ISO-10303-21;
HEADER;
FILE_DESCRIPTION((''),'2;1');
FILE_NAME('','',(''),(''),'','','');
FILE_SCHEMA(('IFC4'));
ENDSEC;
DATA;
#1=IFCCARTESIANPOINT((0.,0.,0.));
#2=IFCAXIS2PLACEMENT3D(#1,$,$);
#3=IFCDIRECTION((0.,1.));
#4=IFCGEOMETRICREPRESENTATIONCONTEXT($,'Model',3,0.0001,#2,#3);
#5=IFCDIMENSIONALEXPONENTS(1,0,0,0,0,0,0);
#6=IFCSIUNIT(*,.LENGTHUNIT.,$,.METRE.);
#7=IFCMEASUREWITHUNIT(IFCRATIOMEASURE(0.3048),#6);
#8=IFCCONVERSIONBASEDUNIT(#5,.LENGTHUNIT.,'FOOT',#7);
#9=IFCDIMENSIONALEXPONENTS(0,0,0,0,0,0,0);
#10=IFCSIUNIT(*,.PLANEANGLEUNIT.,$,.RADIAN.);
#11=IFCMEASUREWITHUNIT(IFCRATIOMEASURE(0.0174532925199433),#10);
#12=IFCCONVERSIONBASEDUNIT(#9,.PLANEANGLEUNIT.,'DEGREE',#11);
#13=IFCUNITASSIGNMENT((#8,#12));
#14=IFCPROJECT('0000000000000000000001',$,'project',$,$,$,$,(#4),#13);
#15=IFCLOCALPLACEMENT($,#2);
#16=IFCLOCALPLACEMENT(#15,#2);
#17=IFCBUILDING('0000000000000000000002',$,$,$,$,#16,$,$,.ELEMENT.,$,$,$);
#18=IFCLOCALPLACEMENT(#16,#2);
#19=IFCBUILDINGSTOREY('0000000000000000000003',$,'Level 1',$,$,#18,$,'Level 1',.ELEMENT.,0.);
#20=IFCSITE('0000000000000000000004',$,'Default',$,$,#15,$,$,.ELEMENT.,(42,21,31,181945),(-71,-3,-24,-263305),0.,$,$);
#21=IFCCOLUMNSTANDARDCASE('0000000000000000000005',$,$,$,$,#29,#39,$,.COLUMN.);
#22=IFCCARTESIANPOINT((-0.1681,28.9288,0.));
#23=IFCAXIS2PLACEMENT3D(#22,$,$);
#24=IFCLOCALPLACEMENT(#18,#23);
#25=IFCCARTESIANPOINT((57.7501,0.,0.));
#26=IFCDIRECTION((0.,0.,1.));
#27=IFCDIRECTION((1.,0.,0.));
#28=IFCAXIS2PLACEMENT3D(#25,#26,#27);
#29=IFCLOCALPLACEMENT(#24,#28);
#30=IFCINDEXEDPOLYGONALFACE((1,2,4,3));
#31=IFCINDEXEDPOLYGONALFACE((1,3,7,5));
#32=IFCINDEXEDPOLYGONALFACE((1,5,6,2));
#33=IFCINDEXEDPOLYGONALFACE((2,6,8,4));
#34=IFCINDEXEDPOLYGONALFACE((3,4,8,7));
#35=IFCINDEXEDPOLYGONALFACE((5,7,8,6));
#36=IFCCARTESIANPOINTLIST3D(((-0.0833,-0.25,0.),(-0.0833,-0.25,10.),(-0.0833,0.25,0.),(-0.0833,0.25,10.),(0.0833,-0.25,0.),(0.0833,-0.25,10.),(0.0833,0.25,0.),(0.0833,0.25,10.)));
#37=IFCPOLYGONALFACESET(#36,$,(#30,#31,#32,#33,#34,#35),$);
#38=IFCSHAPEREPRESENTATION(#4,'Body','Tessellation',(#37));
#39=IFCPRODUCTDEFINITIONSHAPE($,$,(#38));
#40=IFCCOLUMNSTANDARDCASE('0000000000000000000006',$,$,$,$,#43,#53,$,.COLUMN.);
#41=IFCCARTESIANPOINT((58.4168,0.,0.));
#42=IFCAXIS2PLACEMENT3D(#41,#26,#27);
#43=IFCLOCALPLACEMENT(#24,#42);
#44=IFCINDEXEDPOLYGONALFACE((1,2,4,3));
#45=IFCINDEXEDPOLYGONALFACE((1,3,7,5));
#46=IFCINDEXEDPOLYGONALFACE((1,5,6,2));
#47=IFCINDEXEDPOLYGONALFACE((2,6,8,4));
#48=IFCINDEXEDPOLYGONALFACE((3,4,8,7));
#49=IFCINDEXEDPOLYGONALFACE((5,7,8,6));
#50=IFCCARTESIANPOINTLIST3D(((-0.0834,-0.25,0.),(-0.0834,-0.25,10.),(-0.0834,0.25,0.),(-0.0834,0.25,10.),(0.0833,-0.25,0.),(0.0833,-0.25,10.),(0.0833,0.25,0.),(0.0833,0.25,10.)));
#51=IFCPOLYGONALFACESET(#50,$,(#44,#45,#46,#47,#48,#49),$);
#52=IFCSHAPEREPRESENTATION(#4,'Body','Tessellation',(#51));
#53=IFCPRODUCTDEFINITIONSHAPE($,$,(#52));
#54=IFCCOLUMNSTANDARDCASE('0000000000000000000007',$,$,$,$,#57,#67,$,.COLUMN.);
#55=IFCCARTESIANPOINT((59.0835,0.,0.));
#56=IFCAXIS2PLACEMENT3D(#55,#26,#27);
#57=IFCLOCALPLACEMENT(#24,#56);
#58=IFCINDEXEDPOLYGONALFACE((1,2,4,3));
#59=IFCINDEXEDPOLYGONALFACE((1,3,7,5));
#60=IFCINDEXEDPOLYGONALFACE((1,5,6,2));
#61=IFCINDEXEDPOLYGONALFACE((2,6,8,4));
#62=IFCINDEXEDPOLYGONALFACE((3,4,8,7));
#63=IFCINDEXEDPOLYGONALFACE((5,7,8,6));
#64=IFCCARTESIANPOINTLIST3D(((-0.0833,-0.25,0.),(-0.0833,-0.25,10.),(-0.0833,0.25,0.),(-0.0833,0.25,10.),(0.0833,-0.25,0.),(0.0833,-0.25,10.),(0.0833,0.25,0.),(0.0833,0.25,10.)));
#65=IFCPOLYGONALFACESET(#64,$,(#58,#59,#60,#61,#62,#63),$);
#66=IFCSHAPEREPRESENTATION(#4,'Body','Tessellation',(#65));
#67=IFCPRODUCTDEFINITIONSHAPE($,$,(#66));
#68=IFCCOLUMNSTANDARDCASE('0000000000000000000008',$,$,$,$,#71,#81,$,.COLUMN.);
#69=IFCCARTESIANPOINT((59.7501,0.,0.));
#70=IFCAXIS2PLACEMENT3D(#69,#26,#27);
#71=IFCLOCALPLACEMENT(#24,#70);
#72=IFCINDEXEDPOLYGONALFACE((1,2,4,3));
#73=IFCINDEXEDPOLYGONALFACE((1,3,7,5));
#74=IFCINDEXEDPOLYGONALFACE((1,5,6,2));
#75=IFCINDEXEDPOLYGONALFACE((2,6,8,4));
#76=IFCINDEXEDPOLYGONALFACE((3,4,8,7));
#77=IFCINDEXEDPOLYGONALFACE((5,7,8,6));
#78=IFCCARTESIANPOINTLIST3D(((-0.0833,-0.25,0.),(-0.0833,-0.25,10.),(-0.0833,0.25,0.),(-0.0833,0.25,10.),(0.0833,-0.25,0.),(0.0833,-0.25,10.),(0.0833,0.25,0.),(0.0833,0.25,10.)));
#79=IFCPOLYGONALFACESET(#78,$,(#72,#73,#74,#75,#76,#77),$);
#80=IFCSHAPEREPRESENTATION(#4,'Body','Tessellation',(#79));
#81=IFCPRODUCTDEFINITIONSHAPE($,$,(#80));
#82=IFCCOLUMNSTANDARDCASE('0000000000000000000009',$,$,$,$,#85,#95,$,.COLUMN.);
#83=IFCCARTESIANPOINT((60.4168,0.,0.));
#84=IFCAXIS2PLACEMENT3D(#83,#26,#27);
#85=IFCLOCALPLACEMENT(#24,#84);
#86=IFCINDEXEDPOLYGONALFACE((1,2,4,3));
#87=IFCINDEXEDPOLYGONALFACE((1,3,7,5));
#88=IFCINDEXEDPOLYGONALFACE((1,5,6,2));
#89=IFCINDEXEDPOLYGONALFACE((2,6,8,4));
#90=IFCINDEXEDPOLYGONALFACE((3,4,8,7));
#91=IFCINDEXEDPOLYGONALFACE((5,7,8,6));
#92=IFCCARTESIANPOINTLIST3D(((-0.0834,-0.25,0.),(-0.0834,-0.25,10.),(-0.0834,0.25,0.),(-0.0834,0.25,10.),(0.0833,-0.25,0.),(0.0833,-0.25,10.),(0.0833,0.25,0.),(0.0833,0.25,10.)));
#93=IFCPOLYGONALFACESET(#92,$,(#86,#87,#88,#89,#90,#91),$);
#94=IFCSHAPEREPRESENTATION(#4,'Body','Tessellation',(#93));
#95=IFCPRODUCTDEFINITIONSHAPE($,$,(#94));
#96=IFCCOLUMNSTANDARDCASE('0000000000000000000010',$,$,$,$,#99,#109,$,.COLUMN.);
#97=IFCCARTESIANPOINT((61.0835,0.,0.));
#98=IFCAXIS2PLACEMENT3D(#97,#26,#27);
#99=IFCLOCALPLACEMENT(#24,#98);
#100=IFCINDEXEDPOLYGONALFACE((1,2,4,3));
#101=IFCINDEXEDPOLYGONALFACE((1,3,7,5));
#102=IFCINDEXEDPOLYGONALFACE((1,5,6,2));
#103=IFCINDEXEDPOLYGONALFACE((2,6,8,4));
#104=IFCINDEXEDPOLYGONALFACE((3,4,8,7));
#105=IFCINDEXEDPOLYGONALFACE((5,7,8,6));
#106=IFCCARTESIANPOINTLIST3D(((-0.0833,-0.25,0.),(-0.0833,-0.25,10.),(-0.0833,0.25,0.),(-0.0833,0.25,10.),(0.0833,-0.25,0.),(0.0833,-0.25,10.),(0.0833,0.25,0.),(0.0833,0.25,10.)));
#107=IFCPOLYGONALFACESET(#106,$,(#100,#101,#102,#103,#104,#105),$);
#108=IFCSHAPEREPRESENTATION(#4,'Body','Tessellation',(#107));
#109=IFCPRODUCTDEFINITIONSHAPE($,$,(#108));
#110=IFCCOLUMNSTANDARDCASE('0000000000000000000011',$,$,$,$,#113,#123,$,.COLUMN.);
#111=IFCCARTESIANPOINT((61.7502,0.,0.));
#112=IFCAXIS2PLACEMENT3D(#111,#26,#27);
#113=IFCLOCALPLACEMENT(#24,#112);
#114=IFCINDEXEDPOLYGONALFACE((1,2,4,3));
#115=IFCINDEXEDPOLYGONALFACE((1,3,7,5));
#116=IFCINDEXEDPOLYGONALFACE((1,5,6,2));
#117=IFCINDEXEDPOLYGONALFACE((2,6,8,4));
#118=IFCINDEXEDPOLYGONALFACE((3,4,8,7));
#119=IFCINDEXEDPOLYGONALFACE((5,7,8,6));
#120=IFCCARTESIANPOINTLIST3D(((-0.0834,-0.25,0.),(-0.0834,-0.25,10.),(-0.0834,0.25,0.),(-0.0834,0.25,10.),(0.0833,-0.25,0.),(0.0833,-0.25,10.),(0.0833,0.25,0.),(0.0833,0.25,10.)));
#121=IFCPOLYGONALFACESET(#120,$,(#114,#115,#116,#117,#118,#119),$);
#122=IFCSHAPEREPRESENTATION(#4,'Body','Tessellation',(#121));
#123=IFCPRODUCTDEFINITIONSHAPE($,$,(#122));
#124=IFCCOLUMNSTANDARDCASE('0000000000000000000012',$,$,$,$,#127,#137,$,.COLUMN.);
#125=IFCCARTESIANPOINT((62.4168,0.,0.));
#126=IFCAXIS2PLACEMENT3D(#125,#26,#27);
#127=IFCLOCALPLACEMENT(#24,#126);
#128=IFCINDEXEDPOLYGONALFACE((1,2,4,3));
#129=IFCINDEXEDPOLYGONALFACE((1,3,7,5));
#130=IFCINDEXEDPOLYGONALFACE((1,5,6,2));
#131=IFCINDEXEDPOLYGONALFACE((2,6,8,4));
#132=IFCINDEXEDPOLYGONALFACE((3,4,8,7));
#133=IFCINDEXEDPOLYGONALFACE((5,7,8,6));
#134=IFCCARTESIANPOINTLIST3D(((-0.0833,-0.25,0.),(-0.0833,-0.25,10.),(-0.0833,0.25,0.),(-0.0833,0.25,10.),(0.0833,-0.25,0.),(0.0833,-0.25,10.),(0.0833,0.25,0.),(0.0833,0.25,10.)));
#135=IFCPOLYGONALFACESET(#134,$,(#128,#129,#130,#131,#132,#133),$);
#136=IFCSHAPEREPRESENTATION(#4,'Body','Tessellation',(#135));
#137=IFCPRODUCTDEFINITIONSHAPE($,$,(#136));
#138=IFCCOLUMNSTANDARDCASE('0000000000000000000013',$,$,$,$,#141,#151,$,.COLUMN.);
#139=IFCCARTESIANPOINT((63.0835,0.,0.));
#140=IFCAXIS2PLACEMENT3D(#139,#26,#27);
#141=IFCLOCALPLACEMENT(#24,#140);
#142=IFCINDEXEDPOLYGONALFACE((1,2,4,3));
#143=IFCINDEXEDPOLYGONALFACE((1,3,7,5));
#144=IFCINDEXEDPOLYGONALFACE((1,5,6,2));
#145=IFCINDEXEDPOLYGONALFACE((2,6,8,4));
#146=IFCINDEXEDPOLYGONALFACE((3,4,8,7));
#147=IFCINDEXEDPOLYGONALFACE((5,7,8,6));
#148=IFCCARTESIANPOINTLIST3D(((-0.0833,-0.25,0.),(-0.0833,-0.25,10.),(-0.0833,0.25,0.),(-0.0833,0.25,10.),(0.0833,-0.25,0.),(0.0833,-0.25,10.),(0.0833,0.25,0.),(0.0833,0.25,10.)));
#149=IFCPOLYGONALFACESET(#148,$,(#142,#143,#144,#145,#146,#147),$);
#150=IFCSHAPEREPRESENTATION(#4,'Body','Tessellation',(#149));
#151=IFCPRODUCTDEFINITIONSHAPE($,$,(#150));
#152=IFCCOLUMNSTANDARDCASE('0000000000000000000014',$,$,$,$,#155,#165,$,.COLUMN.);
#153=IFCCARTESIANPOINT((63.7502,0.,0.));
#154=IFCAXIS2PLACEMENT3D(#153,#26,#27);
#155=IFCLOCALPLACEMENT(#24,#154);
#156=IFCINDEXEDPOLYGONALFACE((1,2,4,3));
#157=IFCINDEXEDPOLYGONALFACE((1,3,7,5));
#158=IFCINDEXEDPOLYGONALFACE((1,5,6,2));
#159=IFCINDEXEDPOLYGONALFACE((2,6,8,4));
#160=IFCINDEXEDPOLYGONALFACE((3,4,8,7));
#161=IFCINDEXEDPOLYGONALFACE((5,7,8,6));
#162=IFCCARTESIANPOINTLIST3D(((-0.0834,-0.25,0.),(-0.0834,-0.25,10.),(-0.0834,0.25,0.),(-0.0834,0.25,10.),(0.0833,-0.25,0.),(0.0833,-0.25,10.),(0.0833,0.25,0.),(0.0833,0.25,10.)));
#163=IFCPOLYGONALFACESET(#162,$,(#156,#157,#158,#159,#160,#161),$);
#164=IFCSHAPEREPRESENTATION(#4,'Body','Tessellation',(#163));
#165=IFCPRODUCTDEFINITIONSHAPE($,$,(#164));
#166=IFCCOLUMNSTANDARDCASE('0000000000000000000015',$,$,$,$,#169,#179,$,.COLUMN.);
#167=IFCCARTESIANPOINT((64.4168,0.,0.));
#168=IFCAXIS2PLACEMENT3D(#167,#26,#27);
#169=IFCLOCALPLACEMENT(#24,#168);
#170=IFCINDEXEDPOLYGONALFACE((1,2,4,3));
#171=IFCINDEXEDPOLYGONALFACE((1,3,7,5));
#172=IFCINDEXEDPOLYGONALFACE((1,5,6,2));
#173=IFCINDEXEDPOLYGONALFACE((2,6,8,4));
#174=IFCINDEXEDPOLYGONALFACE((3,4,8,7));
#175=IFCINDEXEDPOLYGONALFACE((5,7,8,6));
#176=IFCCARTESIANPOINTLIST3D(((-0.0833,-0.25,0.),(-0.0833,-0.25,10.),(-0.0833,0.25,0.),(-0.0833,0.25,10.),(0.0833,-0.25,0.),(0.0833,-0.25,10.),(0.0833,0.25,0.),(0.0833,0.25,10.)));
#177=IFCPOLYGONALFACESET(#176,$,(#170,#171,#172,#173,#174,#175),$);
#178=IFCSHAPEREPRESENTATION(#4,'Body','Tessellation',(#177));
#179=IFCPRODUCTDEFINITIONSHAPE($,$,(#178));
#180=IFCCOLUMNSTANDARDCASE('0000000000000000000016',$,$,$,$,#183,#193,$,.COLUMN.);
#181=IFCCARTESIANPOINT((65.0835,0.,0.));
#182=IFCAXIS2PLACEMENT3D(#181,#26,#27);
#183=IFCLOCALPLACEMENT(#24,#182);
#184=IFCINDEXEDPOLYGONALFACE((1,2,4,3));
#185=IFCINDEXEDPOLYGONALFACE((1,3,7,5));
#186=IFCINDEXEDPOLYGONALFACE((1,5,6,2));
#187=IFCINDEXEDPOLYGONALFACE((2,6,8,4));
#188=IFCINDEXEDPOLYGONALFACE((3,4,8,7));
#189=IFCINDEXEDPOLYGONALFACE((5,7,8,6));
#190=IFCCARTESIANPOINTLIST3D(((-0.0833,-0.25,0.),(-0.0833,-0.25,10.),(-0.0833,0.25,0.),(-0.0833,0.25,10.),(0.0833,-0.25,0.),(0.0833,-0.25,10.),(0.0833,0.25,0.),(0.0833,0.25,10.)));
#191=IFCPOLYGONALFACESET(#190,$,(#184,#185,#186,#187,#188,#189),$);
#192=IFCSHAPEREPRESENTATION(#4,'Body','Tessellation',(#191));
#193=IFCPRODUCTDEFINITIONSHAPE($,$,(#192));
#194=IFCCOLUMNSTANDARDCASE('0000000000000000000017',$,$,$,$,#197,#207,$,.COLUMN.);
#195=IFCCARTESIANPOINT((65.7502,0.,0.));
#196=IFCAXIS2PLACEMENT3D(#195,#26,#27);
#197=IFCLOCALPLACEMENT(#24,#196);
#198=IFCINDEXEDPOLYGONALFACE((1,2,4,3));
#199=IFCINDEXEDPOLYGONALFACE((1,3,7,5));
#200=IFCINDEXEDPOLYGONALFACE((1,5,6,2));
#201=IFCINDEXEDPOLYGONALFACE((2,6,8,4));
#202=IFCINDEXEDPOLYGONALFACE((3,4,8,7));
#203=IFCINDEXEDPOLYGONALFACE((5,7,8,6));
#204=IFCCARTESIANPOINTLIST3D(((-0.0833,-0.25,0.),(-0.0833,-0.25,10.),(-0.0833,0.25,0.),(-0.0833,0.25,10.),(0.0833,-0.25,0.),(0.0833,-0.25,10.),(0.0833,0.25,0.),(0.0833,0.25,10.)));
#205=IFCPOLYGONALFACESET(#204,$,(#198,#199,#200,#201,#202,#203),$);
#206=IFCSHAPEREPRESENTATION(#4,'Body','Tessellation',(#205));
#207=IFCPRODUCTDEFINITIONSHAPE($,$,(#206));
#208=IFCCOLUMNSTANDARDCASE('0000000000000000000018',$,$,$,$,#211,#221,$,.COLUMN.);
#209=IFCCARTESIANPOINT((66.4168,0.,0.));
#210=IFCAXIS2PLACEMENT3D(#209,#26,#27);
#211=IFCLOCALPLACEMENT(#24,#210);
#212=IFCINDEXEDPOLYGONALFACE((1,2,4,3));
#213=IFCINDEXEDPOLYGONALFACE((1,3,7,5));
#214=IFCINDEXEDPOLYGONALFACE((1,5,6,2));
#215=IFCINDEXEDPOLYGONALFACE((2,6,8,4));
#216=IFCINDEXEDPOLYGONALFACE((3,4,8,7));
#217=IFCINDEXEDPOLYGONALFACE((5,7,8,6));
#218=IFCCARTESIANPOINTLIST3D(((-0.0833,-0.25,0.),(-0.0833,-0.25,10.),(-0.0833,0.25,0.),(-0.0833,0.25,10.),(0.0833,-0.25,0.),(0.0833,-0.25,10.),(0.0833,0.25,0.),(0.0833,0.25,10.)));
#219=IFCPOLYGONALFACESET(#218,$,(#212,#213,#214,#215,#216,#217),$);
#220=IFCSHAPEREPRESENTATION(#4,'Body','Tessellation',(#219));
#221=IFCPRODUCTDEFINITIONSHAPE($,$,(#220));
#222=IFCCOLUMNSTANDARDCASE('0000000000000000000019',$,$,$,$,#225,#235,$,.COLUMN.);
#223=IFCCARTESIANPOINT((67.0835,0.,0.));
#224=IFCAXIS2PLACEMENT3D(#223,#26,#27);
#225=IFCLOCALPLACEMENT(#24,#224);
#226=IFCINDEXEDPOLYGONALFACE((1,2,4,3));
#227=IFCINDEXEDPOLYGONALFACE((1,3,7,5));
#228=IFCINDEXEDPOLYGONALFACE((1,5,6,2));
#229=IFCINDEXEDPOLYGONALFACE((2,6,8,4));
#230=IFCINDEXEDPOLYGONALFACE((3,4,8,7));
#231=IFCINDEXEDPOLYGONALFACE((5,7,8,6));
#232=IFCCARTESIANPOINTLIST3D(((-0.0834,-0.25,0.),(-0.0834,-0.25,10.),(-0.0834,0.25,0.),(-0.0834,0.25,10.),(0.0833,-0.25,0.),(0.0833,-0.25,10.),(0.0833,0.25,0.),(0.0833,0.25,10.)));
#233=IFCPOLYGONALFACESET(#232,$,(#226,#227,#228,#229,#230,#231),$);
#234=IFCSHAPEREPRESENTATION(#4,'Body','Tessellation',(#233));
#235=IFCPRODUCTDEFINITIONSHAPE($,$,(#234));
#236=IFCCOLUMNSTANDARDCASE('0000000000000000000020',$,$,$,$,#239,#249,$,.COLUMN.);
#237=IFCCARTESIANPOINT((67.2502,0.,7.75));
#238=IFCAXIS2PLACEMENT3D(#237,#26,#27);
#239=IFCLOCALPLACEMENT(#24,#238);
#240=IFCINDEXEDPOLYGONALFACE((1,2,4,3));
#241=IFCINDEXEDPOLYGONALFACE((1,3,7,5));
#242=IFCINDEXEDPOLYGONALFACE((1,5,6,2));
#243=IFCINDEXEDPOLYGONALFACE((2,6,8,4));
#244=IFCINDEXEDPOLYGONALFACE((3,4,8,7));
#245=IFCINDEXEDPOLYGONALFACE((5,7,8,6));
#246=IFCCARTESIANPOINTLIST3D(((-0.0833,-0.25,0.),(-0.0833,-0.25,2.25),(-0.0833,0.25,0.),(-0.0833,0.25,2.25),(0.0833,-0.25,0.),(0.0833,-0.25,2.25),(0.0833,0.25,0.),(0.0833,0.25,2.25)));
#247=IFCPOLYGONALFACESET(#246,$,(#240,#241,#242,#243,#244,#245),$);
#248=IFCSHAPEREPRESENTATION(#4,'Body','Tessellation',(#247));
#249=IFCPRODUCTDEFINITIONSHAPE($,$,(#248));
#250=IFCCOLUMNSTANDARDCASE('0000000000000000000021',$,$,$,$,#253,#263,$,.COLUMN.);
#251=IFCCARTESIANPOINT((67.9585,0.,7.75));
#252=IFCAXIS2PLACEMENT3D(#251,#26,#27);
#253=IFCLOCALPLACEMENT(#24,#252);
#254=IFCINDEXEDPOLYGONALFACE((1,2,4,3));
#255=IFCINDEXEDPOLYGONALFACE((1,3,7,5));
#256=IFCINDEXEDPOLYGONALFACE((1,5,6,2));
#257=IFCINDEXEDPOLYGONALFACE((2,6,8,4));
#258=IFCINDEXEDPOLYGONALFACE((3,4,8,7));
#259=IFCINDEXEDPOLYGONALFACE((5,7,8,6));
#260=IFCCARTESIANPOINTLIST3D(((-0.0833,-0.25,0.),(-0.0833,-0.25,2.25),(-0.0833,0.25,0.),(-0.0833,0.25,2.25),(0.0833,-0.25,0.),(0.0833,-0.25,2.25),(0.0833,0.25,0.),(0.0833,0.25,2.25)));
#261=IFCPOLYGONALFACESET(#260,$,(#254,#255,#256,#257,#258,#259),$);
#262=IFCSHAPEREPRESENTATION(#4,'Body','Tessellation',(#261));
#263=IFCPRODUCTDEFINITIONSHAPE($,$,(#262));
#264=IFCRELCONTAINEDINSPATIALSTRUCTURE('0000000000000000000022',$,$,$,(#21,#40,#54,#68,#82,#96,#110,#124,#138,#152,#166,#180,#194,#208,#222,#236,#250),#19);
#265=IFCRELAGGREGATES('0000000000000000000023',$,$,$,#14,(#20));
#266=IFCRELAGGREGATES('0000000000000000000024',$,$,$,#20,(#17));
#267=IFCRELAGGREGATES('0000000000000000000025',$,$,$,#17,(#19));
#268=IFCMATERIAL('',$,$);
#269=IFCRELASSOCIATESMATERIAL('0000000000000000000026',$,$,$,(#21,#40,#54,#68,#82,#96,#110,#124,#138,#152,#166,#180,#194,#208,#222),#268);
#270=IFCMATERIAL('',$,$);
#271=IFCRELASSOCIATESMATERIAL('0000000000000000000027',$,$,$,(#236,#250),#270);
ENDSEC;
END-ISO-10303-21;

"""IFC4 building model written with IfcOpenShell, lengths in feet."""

from ifc_helpers import new_model, entity, si_unit, converted_unit, direction, frame, origin, place, context, project, spatial, rectangle, extrude, material, element, save


model = new_model("IFC4")

# Units and contexts
model_context = context("Model", 3, precision=0.0001, world=origin(), true_north=direction((0.0, 1.0)))
ifc_project = project(units=[converted_unit("LENGTHUNIT", "FOOT", entity("IfcRatioMeasure", 0.3048), si_unit("LENGTHUNIT", "METRE"), dimensions=[1, 0, 0, 0, 0, 0, 0]), converted_unit("PLANEANGLEUNIT", "DEGREE", entity("IfcRatioMeasure", 0.0174532925199433), si_unit("PLANEANGLEUNIT", "RADIAN"), dimensions=[0, 0, 0, 0, 0, 0, 0])], contexts=[model_context])

# Site, building, storey
site_placement = place(None, origin())
site = spatial("IfcSite", under=ifc_project, at=site_placement, Name="Default", CompositionType="ELEMENT", RefLatitude=(42, 21, 31, 181945), RefLongitude=(-71, -3, -24, -263305), RefElevation=0.0)
building_placement = place(site_placement, origin())
building = spatial("IfcBuilding", under=site, at=building_placement, CompositionType="ELEMENT")
storey_placement = place(building_placement, origin())
storey = spatial("IfcBuildingStorey", under=building, at=storey_placement, Name="Level 1", LongName="Level 1", CompositionType="ELEMENT", Elevation=0.0)

# Columns
ifc_material_1 = material(Name="")
placement = place(storey_placement, frame((-0.1681, 28.9288, 0.0)))
for number, where, z_axis, x_axis in (
    (1, (57.7501, 0.0, 0.0), (0.0, 0.0, 1.0), (1.0, 0.0, 0.0)),
    (2, (58.4168, 0.0, 0.0), (0.0, 0.0, 1.0), (1.0, 0.0, 0.0)),
    (3, (59.0835, 0.0, 0.0), (0.0, 0.0, 1.0), (1.0, 0.0, 0.0)),
    (4, (59.7501, 0.0, 0.0), (0.0, 0.0, 1.0), (1.0, 0.0, 0.0)),
    (5, (60.4168, 0.0, 0.0), (0.0, 0.0, 1.0), (1.0, 0.0, 0.0)),
    (6, (61.0835, 0.0, 0.0), (0.0, 0.0, 1.0), (1.0, 0.0, 0.0)),
    (7, (61.7502, 0.0, 0.0), (0.0, 0.0, 1.0), (1.0, 0.0, 0.0)),
    (8, (62.4168, 0.0, 0.0), (0.0, 0.0, 1.0), (1.0, 0.0, 0.0)),
    (9, (63.0835, 0.0, 0.0), (0.0, 0.0, 1.0), (1.0, 0.0, 0.0)),
    (10, (63.7502, 0.0, 0.0), (0.0, 0.0, 1.0), (1.0, 0.0, 0.0)),
    (11, (64.4168, 0.0, 0.0), (0.0, 0.0, 1.0), (1.0, 0.0, 0.0)),
    (12, (65.0835, 0.0, 0.0), (0.0, 0.0, 1.0), (1.0, 0.0, 0.0)),
    (13, (65.7502, 0.0, 0.0), (0.0, 0.0, 1.0), (1.0, 0.0, 0.0)),
    (14, (66.4168, 0.0, 0.0), (0.0, 0.0, 1.0), (1.0, 0.0, 0.0)),
    (15, (67.0835, 0.0, 0.0), (0.0, 0.0, 1.0), (1.0, 0.0, 0.0)),
):
    element("IfcColumnStandardCase", number, at=place(placement, frame(where, z_axis=z_axis, x_axis=x_axis)), inside=storey, material=ifc_material_1, PredefinedType="COLUMN", context=model_context, shape_type="SweptSolid", body=[
        extrude(rectangle(XDim=0.1667, YDim=0.5), origin(), (0.0, 0.0, 1.0), 10.0),
    ])
ifc_material_2 = material(Name="")
for number, where, z_axis, x_axis in (
    (16, (67.2502, 0.0, 7.75), (0.0, 0.0, 1.0), (1.0, 0.0, 0.0)),
    (17, (67.9585, 0.0, 7.75), (0.0, 0.0, 1.0), (1.0, 0.0, 0.0)),
):
    element("IfcColumnStandardCase", number, at=place(placement, frame(where, z_axis=z_axis, x_axis=x_axis)), inside=storey, material=ifc_material_2, PredefinedType="COLUMN", context=model_context, shape_type="SweptSolid", body=[
        extrude(rectangle(XDim=0.1667, YDim=0.5), origin(), (0.0, 0.0, 1.0), 2.25),
    ])

save(model, "model.ifc")
